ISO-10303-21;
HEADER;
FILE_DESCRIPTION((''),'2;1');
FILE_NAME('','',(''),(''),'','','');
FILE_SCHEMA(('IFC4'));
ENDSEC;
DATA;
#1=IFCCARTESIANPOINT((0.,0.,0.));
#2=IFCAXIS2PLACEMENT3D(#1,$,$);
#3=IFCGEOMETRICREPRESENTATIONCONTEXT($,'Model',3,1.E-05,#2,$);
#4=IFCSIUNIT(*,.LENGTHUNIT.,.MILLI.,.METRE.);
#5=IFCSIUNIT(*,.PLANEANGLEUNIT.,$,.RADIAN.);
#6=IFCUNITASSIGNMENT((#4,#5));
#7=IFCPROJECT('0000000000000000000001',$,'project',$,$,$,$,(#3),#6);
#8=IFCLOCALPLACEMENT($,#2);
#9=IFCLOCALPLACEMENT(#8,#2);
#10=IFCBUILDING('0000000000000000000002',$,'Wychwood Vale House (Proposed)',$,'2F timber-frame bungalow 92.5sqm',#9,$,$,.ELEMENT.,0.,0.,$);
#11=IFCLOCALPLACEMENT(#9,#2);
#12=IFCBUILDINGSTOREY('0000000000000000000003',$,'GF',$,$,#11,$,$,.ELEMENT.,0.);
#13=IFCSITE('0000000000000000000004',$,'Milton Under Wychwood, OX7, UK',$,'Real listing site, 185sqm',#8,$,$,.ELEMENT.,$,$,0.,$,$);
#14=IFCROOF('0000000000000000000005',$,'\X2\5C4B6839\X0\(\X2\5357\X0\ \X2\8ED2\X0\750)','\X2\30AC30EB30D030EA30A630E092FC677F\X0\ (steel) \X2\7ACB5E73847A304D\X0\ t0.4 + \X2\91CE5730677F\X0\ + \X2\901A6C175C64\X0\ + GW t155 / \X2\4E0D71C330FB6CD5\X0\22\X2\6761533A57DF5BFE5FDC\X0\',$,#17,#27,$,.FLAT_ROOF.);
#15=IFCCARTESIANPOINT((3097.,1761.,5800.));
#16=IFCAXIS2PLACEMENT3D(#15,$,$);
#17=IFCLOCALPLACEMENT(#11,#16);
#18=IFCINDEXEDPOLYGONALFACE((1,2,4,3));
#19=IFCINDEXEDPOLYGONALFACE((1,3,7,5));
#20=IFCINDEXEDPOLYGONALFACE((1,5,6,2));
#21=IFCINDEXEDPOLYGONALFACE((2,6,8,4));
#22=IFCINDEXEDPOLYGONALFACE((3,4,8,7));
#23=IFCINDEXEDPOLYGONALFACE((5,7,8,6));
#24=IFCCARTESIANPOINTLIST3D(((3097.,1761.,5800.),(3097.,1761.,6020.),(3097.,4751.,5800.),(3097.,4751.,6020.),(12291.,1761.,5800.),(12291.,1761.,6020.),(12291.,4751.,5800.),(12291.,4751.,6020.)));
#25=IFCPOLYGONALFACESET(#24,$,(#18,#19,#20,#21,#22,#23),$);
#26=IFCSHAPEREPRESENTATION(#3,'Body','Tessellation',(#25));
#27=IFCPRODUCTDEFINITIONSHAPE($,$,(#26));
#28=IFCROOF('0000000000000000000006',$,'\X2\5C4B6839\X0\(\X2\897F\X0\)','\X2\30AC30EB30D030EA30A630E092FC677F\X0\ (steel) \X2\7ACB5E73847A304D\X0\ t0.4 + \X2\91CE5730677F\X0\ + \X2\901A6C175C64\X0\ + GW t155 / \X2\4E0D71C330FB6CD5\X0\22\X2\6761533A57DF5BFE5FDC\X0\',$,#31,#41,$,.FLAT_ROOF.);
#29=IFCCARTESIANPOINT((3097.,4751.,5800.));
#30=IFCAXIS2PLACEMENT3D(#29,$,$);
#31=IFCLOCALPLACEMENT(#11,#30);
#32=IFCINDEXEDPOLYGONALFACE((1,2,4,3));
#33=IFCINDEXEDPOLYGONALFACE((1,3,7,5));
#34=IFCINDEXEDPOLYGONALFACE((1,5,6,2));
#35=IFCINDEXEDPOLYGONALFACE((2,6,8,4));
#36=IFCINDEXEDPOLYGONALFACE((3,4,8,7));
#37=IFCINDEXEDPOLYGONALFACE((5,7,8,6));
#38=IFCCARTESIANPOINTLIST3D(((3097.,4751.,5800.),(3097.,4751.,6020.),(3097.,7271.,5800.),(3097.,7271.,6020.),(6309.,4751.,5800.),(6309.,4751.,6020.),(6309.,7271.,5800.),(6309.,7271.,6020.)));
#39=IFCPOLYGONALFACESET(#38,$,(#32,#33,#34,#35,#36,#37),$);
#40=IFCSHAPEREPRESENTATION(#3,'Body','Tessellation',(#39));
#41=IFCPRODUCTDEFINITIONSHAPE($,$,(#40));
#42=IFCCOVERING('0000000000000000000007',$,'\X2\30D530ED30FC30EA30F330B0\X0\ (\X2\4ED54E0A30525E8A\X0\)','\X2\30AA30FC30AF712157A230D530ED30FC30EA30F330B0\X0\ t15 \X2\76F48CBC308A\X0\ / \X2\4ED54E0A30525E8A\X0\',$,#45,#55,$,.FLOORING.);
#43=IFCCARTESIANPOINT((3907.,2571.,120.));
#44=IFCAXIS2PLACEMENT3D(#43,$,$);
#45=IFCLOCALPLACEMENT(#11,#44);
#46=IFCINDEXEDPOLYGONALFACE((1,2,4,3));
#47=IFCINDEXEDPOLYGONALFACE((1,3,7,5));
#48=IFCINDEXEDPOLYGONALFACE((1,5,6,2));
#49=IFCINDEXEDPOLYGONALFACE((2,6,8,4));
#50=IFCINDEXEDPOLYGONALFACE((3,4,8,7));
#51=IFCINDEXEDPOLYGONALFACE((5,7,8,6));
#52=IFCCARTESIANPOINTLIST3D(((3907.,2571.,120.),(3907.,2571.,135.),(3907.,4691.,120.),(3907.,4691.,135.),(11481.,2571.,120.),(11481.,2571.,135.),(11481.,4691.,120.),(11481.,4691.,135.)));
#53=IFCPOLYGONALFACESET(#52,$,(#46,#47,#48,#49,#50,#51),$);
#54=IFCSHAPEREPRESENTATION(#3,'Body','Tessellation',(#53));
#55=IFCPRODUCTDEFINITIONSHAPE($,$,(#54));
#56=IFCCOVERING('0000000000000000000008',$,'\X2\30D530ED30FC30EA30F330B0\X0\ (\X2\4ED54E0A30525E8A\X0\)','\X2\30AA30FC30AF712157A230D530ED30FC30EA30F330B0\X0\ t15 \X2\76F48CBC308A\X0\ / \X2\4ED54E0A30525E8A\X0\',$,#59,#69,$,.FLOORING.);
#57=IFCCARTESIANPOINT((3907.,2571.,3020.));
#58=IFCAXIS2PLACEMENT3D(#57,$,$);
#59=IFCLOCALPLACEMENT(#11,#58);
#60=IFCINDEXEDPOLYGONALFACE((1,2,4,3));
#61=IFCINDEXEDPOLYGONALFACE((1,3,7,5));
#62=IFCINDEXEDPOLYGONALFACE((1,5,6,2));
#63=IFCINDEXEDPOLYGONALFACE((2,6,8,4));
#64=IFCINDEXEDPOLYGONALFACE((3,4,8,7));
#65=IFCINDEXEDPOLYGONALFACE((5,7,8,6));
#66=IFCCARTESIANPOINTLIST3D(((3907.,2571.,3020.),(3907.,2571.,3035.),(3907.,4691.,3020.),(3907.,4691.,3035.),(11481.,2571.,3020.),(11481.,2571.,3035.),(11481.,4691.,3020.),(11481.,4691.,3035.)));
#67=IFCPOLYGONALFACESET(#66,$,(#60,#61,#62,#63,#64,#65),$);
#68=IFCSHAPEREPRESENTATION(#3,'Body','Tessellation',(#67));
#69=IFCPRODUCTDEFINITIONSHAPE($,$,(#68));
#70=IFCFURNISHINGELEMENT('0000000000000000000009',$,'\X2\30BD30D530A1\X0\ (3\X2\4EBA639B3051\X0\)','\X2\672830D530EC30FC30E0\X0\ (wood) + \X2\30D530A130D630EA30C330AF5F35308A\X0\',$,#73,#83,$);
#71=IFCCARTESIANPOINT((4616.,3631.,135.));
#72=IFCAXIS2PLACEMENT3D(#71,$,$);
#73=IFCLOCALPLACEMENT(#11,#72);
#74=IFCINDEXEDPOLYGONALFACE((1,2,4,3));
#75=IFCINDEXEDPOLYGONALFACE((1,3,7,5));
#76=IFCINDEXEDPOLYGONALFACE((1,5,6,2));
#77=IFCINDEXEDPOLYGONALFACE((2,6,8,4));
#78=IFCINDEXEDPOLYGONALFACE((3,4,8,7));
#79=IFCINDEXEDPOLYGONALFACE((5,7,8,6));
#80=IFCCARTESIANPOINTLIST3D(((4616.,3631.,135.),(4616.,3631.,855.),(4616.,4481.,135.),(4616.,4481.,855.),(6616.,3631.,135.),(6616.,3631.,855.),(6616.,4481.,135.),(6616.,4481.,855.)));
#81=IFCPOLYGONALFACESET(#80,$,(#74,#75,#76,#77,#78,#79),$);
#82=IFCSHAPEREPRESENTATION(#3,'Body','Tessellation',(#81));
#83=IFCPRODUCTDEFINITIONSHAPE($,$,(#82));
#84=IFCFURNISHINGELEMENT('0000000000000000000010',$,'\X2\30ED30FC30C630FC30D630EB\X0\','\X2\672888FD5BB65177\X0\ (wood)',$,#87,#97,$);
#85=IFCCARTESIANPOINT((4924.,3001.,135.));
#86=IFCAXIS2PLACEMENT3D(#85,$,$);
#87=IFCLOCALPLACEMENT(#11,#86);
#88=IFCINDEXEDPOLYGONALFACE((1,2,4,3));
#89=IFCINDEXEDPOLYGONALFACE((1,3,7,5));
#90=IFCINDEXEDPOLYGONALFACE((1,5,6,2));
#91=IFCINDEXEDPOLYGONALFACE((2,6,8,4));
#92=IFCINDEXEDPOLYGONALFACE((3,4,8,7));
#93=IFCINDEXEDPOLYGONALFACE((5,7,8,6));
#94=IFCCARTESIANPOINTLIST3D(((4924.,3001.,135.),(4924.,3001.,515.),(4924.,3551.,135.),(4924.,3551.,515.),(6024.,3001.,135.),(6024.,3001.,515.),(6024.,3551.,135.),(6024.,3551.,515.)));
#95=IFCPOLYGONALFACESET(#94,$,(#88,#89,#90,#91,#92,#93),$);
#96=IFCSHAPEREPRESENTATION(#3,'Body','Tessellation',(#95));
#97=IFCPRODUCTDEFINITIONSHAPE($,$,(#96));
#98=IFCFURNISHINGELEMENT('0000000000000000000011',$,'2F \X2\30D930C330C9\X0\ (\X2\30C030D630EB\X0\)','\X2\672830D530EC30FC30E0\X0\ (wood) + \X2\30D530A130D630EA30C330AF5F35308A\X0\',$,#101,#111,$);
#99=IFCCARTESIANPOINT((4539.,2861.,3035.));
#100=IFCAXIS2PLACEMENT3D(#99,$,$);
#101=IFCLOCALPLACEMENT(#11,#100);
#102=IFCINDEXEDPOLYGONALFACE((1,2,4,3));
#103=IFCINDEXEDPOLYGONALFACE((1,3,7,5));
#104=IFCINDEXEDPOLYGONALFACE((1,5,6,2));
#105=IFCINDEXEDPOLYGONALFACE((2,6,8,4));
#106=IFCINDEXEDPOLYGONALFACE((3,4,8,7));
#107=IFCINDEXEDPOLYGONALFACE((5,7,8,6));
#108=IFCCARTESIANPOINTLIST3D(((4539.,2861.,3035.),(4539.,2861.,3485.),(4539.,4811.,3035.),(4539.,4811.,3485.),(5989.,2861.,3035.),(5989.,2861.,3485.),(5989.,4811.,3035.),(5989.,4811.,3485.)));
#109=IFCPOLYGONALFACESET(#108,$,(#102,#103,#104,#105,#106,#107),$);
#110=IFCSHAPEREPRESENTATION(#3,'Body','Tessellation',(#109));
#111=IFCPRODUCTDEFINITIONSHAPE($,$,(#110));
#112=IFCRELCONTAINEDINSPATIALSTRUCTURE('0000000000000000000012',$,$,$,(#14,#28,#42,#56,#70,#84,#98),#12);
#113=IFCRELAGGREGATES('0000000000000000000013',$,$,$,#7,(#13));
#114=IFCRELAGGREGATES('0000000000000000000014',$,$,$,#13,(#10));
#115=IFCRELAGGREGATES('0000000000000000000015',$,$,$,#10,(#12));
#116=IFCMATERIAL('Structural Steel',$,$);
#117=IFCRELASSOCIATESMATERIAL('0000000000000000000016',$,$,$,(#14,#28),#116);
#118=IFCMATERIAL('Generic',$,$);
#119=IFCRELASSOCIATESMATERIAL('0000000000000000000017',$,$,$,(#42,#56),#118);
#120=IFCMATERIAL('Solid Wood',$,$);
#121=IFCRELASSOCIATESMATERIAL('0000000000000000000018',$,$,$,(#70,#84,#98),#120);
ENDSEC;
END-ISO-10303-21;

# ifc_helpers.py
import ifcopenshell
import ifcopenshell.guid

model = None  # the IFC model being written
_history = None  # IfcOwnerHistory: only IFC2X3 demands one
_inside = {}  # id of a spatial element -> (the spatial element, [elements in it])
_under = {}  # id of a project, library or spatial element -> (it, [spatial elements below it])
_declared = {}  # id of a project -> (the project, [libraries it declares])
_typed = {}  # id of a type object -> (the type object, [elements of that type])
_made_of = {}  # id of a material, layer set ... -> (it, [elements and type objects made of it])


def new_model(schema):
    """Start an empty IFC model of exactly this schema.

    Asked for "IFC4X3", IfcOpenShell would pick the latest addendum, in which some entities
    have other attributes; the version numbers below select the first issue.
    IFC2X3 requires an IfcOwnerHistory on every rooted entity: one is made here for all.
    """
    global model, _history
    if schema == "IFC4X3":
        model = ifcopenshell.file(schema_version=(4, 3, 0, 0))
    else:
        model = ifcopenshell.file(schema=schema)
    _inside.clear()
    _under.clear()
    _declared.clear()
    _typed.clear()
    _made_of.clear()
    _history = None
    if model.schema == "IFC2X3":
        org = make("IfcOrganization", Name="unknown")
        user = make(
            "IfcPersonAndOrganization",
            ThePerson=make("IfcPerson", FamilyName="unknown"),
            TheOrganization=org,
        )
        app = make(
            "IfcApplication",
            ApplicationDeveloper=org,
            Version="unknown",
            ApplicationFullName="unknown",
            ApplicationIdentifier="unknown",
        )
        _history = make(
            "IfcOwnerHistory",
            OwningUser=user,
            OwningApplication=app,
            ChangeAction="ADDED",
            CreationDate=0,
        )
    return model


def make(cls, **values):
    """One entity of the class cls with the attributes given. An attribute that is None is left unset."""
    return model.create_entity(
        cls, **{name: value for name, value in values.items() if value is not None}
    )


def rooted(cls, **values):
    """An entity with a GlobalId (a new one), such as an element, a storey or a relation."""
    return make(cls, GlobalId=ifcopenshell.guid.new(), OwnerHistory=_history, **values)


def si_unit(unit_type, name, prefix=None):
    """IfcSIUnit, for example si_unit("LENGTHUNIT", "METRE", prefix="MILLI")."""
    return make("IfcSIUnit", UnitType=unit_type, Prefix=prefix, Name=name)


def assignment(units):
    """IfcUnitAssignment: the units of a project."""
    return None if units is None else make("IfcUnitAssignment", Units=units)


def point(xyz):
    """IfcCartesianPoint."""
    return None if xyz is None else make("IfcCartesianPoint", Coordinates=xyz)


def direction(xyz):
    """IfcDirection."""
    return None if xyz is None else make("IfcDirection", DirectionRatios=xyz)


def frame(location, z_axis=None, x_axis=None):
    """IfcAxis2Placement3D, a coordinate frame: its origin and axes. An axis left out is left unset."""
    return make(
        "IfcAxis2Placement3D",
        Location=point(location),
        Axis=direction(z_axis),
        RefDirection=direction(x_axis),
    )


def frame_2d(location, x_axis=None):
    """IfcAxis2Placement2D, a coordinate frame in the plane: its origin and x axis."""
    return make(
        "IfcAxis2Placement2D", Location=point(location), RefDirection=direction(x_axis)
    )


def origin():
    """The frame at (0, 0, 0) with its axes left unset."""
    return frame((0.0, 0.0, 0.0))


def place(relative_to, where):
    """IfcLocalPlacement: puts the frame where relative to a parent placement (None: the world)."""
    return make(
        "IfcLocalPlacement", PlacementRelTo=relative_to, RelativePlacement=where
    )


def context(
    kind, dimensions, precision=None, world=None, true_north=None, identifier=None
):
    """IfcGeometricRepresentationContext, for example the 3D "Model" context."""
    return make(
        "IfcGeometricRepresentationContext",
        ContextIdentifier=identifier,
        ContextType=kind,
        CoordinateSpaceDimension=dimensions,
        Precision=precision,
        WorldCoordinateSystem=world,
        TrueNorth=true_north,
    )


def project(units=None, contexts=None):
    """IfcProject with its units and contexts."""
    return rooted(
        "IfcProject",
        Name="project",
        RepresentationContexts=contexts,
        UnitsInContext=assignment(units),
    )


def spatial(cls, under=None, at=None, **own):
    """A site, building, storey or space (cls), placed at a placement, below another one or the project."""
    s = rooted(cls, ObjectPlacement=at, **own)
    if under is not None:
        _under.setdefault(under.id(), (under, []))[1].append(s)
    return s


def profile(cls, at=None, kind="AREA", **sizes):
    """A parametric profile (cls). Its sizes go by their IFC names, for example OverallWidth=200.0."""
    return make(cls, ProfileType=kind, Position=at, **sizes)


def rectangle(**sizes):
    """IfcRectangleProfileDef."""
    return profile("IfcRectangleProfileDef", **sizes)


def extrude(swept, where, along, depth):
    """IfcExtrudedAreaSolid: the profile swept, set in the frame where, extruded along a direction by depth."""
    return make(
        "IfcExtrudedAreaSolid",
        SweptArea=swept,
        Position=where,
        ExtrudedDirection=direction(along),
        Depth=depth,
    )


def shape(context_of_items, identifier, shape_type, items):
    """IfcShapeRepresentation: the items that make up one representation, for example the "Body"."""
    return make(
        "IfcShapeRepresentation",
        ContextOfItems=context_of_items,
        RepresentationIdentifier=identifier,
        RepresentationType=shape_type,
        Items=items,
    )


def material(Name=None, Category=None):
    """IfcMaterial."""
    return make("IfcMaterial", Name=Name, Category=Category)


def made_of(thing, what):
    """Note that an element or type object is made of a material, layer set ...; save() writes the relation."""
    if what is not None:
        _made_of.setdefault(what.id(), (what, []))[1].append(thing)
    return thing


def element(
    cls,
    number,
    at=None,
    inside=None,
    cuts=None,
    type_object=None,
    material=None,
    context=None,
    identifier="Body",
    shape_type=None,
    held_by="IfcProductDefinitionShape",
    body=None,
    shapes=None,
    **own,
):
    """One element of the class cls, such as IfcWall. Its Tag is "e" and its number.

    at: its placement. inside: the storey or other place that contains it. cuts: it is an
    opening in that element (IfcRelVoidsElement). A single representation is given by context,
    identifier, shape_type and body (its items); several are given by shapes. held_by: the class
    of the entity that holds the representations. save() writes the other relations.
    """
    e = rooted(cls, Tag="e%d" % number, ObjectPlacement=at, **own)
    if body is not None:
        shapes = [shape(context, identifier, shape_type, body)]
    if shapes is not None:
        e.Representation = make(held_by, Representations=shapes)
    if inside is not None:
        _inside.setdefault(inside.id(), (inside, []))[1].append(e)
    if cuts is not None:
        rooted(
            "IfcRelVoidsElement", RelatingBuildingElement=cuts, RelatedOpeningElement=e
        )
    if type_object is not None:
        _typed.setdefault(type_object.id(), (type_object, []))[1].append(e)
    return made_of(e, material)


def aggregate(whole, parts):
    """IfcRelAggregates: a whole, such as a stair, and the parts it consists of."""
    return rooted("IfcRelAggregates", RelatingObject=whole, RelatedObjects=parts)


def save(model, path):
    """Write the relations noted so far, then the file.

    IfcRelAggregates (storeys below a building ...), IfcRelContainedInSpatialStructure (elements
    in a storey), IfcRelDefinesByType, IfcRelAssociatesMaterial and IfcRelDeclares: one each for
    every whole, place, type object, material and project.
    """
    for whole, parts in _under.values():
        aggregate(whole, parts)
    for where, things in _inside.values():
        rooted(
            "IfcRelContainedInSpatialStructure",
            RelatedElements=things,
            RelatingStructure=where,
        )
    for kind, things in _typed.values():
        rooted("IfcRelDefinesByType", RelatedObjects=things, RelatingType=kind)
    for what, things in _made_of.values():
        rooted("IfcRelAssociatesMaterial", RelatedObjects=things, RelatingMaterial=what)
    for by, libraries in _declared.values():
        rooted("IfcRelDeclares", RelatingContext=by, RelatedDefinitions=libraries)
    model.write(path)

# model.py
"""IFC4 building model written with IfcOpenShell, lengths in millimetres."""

from ifc_helpers import new_model, si_unit, frame, frame_2d, origin, place, context, project, spatial, rectangle, extrude, material, element, save


model = new_model("IFC4")

# Units and contexts
model_context = context("Model", 3, precision=1e-05, world=origin())
ifc_project = project(units=[si_unit("LENGTHUNIT", "METRE", prefix="MILLI"), si_unit("PLANEANGLEUNIT", "RADIAN")], contexts=[model_context])

# Site, building, storey
site_placement = place(None, origin())
site = spatial("IfcSite", under=ifc_project, at=site_placement, Name="Milton Under Wychwood, OX7, UK", ObjectType="Real listing site, 185sqm", CompositionType="ELEMENT", RefElevation=0.0)
building_placement = place(site_placement, origin())
building = spatial("IfcBuilding", under=site, at=building_placement, Name="Wychwood Vale House (Proposed)", ObjectType="2F timber-frame bungalow 92.5sqm", CompositionType="ELEMENT", ElevationOfRefHeight=0.0, ElevationOfTerrain=0.0)
storey_placement = place(building_placement, origin())
storey = spatial("IfcBuildingStorey", under=building, at=storey_placement, Name="GF", CompositionType="ELEMENT", Elevation=0.0)

# Shared definitions
ifc_material_1 = material(Name="Solid Wood")

# Roofs
ifc_material_2 = material(Name="Structural Steel")
roof_1_placement = place(storey_placement, frame((3097.0, 1761.0, 5800.0)))
element("IfcRoof", 1, at=roof_1_placement, inside=storey, material=ifc_material_2, Name="屋根(南 軒750)", Description="ガルバリウム鋼板 (steel) 立平葺き t0.4 + 野地板 + 通気層 + GW t155 / 不燃・法22条区域対応", PredefinedType="FLAT_ROOF", context=model_context, shape_type="SweptSolid", body=[
    extrude(rectangle(XDim=9194.0, YDim=2990.0, at=frame_2d((4597.0, 1495.0))), frame((3097.0, 1761.0, 5800.0)), (0.0, 0.0, 1.0), 220.0),
])
roof_2_placement = place(storey_placement, frame((3097.0, 4751.0, 5800.0)))
element("IfcRoof", 2, at=roof_2_placement, inside=storey, material=ifc_material_2, Name="屋根(西)", Description="ガルバリウム鋼板 (steel) 立平葺き t0.4 + 野地板 + 通気層 + GW t155 / 不燃・法22条区域対応", PredefinedType="FLAT_ROOF", context=model_context, shape_type="SweptSolid", body=[
    extrude(rectangle(XDim=3212.0, YDim=2520.0, at=frame_2d((1606.0, 1260.0))), frame((3097.0, 4751.0, 5800.0)), (0.0, 0.0, 1.0), 220.0),
])

# Coverings
ifc_material_3 = material(Name="Generic")
covering_1_placement = place(storey_placement, frame((3907.0, 2571.0, 120.0)))
element("IfcCovering", 3, at=covering_1_placement, inside=storey, material=ifc_material_3, Name="フローリング (仕上げ床)", Description="オーク無垢フローリング t15 直貼り / 仕上げ床", PredefinedType="FLOORING", context=model_context, shape_type="SweptSolid", body=[
    extrude(rectangle(XDim=7574.0, YDim=2120.0, at=frame_2d((3787.0, 1060.0))), frame((3907.0, 2571.0, 120.0)), (0.0, 0.0, 1.0), 15.0),
])
covering_2_placement = place(storey_placement, frame((3907.0, 2571.0, 3020.0)))
element("IfcCovering", 4, at=covering_2_placement, inside=storey, material=ifc_material_3, Name="フローリング (仕上げ床)", Description="オーク無垢フローリング t15 直貼り / 仕上げ床", PredefinedType="FLOORING", context=model_context, shape_type="SweptSolid", body=[
    extrude(rectangle(XDim=7574.0, YDim=2120.0, at=frame_2d((3787.0, 1060.0))), frame((3907.0, 2571.0, 3020.0)), (0.0, 0.0, 1.0), 15.0),
])

# Furnishing elements
furnishing_1_placement = place(storey_placement, frame((4616.0, 3631.0, 135.0)))
element("IfcFurnishingElement", 5, at=furnishing_1_placement, inside=storey, material=ifc_material_1, Name="ソファ (3人掛け)", Description="木フレーム (wood) + ファブリック張り", context=model_context, shape_type="SweptSolid", body=[
    extrude(rectangle(XDim=2000.0, YDim=850.0, at=frame_2d((1000.0, 425.0))), frame((4616.0, 3631.0, 135.0)), (0.0, 0.0, 1.0), 720.0),
])
furnishing_2_placement = place(storey_placement, frame((4924.0, 3001.0, 135.0)))
element("IfcFurnishingElement", 6, at=furnishing_2_placement, inside=storey, material=ifc_material_1, Name="ローテーブル", Description="木製家具 (wood)", context=model_context, shape_type="SweptSolid", body=[
    extrude(rectangle(XDim=1100.0, YDim=550.0, at=frame_2d((550.0, 275.0))), frame((4924.0, 3001.0, 135.0)), (0.0, 0.0, 1.0), 380.0),
])
furnishing_3_placement = place(storey_placement, frame((4539.0, 2861.0, 3035.0)))
element("IfcFurnishingElement", 7, at=furnishing_3_placement, inside=storey, material=ifc_material_1, Name="2F ベッド (ダブル)", Description="木フレーム (wood) + ファブリック張り", context=model_context, shape_type="SweptSolid", body=[
    extrude(rectangle(XDim=1450.0, YDim=1950.0, at=frame_2d((725.0, 975.0))), frame((4539.0, 2861.0, 3035.0)), (0.0, 0.0, 1.0), 450.0),
])

save(model, "model.ifc")
